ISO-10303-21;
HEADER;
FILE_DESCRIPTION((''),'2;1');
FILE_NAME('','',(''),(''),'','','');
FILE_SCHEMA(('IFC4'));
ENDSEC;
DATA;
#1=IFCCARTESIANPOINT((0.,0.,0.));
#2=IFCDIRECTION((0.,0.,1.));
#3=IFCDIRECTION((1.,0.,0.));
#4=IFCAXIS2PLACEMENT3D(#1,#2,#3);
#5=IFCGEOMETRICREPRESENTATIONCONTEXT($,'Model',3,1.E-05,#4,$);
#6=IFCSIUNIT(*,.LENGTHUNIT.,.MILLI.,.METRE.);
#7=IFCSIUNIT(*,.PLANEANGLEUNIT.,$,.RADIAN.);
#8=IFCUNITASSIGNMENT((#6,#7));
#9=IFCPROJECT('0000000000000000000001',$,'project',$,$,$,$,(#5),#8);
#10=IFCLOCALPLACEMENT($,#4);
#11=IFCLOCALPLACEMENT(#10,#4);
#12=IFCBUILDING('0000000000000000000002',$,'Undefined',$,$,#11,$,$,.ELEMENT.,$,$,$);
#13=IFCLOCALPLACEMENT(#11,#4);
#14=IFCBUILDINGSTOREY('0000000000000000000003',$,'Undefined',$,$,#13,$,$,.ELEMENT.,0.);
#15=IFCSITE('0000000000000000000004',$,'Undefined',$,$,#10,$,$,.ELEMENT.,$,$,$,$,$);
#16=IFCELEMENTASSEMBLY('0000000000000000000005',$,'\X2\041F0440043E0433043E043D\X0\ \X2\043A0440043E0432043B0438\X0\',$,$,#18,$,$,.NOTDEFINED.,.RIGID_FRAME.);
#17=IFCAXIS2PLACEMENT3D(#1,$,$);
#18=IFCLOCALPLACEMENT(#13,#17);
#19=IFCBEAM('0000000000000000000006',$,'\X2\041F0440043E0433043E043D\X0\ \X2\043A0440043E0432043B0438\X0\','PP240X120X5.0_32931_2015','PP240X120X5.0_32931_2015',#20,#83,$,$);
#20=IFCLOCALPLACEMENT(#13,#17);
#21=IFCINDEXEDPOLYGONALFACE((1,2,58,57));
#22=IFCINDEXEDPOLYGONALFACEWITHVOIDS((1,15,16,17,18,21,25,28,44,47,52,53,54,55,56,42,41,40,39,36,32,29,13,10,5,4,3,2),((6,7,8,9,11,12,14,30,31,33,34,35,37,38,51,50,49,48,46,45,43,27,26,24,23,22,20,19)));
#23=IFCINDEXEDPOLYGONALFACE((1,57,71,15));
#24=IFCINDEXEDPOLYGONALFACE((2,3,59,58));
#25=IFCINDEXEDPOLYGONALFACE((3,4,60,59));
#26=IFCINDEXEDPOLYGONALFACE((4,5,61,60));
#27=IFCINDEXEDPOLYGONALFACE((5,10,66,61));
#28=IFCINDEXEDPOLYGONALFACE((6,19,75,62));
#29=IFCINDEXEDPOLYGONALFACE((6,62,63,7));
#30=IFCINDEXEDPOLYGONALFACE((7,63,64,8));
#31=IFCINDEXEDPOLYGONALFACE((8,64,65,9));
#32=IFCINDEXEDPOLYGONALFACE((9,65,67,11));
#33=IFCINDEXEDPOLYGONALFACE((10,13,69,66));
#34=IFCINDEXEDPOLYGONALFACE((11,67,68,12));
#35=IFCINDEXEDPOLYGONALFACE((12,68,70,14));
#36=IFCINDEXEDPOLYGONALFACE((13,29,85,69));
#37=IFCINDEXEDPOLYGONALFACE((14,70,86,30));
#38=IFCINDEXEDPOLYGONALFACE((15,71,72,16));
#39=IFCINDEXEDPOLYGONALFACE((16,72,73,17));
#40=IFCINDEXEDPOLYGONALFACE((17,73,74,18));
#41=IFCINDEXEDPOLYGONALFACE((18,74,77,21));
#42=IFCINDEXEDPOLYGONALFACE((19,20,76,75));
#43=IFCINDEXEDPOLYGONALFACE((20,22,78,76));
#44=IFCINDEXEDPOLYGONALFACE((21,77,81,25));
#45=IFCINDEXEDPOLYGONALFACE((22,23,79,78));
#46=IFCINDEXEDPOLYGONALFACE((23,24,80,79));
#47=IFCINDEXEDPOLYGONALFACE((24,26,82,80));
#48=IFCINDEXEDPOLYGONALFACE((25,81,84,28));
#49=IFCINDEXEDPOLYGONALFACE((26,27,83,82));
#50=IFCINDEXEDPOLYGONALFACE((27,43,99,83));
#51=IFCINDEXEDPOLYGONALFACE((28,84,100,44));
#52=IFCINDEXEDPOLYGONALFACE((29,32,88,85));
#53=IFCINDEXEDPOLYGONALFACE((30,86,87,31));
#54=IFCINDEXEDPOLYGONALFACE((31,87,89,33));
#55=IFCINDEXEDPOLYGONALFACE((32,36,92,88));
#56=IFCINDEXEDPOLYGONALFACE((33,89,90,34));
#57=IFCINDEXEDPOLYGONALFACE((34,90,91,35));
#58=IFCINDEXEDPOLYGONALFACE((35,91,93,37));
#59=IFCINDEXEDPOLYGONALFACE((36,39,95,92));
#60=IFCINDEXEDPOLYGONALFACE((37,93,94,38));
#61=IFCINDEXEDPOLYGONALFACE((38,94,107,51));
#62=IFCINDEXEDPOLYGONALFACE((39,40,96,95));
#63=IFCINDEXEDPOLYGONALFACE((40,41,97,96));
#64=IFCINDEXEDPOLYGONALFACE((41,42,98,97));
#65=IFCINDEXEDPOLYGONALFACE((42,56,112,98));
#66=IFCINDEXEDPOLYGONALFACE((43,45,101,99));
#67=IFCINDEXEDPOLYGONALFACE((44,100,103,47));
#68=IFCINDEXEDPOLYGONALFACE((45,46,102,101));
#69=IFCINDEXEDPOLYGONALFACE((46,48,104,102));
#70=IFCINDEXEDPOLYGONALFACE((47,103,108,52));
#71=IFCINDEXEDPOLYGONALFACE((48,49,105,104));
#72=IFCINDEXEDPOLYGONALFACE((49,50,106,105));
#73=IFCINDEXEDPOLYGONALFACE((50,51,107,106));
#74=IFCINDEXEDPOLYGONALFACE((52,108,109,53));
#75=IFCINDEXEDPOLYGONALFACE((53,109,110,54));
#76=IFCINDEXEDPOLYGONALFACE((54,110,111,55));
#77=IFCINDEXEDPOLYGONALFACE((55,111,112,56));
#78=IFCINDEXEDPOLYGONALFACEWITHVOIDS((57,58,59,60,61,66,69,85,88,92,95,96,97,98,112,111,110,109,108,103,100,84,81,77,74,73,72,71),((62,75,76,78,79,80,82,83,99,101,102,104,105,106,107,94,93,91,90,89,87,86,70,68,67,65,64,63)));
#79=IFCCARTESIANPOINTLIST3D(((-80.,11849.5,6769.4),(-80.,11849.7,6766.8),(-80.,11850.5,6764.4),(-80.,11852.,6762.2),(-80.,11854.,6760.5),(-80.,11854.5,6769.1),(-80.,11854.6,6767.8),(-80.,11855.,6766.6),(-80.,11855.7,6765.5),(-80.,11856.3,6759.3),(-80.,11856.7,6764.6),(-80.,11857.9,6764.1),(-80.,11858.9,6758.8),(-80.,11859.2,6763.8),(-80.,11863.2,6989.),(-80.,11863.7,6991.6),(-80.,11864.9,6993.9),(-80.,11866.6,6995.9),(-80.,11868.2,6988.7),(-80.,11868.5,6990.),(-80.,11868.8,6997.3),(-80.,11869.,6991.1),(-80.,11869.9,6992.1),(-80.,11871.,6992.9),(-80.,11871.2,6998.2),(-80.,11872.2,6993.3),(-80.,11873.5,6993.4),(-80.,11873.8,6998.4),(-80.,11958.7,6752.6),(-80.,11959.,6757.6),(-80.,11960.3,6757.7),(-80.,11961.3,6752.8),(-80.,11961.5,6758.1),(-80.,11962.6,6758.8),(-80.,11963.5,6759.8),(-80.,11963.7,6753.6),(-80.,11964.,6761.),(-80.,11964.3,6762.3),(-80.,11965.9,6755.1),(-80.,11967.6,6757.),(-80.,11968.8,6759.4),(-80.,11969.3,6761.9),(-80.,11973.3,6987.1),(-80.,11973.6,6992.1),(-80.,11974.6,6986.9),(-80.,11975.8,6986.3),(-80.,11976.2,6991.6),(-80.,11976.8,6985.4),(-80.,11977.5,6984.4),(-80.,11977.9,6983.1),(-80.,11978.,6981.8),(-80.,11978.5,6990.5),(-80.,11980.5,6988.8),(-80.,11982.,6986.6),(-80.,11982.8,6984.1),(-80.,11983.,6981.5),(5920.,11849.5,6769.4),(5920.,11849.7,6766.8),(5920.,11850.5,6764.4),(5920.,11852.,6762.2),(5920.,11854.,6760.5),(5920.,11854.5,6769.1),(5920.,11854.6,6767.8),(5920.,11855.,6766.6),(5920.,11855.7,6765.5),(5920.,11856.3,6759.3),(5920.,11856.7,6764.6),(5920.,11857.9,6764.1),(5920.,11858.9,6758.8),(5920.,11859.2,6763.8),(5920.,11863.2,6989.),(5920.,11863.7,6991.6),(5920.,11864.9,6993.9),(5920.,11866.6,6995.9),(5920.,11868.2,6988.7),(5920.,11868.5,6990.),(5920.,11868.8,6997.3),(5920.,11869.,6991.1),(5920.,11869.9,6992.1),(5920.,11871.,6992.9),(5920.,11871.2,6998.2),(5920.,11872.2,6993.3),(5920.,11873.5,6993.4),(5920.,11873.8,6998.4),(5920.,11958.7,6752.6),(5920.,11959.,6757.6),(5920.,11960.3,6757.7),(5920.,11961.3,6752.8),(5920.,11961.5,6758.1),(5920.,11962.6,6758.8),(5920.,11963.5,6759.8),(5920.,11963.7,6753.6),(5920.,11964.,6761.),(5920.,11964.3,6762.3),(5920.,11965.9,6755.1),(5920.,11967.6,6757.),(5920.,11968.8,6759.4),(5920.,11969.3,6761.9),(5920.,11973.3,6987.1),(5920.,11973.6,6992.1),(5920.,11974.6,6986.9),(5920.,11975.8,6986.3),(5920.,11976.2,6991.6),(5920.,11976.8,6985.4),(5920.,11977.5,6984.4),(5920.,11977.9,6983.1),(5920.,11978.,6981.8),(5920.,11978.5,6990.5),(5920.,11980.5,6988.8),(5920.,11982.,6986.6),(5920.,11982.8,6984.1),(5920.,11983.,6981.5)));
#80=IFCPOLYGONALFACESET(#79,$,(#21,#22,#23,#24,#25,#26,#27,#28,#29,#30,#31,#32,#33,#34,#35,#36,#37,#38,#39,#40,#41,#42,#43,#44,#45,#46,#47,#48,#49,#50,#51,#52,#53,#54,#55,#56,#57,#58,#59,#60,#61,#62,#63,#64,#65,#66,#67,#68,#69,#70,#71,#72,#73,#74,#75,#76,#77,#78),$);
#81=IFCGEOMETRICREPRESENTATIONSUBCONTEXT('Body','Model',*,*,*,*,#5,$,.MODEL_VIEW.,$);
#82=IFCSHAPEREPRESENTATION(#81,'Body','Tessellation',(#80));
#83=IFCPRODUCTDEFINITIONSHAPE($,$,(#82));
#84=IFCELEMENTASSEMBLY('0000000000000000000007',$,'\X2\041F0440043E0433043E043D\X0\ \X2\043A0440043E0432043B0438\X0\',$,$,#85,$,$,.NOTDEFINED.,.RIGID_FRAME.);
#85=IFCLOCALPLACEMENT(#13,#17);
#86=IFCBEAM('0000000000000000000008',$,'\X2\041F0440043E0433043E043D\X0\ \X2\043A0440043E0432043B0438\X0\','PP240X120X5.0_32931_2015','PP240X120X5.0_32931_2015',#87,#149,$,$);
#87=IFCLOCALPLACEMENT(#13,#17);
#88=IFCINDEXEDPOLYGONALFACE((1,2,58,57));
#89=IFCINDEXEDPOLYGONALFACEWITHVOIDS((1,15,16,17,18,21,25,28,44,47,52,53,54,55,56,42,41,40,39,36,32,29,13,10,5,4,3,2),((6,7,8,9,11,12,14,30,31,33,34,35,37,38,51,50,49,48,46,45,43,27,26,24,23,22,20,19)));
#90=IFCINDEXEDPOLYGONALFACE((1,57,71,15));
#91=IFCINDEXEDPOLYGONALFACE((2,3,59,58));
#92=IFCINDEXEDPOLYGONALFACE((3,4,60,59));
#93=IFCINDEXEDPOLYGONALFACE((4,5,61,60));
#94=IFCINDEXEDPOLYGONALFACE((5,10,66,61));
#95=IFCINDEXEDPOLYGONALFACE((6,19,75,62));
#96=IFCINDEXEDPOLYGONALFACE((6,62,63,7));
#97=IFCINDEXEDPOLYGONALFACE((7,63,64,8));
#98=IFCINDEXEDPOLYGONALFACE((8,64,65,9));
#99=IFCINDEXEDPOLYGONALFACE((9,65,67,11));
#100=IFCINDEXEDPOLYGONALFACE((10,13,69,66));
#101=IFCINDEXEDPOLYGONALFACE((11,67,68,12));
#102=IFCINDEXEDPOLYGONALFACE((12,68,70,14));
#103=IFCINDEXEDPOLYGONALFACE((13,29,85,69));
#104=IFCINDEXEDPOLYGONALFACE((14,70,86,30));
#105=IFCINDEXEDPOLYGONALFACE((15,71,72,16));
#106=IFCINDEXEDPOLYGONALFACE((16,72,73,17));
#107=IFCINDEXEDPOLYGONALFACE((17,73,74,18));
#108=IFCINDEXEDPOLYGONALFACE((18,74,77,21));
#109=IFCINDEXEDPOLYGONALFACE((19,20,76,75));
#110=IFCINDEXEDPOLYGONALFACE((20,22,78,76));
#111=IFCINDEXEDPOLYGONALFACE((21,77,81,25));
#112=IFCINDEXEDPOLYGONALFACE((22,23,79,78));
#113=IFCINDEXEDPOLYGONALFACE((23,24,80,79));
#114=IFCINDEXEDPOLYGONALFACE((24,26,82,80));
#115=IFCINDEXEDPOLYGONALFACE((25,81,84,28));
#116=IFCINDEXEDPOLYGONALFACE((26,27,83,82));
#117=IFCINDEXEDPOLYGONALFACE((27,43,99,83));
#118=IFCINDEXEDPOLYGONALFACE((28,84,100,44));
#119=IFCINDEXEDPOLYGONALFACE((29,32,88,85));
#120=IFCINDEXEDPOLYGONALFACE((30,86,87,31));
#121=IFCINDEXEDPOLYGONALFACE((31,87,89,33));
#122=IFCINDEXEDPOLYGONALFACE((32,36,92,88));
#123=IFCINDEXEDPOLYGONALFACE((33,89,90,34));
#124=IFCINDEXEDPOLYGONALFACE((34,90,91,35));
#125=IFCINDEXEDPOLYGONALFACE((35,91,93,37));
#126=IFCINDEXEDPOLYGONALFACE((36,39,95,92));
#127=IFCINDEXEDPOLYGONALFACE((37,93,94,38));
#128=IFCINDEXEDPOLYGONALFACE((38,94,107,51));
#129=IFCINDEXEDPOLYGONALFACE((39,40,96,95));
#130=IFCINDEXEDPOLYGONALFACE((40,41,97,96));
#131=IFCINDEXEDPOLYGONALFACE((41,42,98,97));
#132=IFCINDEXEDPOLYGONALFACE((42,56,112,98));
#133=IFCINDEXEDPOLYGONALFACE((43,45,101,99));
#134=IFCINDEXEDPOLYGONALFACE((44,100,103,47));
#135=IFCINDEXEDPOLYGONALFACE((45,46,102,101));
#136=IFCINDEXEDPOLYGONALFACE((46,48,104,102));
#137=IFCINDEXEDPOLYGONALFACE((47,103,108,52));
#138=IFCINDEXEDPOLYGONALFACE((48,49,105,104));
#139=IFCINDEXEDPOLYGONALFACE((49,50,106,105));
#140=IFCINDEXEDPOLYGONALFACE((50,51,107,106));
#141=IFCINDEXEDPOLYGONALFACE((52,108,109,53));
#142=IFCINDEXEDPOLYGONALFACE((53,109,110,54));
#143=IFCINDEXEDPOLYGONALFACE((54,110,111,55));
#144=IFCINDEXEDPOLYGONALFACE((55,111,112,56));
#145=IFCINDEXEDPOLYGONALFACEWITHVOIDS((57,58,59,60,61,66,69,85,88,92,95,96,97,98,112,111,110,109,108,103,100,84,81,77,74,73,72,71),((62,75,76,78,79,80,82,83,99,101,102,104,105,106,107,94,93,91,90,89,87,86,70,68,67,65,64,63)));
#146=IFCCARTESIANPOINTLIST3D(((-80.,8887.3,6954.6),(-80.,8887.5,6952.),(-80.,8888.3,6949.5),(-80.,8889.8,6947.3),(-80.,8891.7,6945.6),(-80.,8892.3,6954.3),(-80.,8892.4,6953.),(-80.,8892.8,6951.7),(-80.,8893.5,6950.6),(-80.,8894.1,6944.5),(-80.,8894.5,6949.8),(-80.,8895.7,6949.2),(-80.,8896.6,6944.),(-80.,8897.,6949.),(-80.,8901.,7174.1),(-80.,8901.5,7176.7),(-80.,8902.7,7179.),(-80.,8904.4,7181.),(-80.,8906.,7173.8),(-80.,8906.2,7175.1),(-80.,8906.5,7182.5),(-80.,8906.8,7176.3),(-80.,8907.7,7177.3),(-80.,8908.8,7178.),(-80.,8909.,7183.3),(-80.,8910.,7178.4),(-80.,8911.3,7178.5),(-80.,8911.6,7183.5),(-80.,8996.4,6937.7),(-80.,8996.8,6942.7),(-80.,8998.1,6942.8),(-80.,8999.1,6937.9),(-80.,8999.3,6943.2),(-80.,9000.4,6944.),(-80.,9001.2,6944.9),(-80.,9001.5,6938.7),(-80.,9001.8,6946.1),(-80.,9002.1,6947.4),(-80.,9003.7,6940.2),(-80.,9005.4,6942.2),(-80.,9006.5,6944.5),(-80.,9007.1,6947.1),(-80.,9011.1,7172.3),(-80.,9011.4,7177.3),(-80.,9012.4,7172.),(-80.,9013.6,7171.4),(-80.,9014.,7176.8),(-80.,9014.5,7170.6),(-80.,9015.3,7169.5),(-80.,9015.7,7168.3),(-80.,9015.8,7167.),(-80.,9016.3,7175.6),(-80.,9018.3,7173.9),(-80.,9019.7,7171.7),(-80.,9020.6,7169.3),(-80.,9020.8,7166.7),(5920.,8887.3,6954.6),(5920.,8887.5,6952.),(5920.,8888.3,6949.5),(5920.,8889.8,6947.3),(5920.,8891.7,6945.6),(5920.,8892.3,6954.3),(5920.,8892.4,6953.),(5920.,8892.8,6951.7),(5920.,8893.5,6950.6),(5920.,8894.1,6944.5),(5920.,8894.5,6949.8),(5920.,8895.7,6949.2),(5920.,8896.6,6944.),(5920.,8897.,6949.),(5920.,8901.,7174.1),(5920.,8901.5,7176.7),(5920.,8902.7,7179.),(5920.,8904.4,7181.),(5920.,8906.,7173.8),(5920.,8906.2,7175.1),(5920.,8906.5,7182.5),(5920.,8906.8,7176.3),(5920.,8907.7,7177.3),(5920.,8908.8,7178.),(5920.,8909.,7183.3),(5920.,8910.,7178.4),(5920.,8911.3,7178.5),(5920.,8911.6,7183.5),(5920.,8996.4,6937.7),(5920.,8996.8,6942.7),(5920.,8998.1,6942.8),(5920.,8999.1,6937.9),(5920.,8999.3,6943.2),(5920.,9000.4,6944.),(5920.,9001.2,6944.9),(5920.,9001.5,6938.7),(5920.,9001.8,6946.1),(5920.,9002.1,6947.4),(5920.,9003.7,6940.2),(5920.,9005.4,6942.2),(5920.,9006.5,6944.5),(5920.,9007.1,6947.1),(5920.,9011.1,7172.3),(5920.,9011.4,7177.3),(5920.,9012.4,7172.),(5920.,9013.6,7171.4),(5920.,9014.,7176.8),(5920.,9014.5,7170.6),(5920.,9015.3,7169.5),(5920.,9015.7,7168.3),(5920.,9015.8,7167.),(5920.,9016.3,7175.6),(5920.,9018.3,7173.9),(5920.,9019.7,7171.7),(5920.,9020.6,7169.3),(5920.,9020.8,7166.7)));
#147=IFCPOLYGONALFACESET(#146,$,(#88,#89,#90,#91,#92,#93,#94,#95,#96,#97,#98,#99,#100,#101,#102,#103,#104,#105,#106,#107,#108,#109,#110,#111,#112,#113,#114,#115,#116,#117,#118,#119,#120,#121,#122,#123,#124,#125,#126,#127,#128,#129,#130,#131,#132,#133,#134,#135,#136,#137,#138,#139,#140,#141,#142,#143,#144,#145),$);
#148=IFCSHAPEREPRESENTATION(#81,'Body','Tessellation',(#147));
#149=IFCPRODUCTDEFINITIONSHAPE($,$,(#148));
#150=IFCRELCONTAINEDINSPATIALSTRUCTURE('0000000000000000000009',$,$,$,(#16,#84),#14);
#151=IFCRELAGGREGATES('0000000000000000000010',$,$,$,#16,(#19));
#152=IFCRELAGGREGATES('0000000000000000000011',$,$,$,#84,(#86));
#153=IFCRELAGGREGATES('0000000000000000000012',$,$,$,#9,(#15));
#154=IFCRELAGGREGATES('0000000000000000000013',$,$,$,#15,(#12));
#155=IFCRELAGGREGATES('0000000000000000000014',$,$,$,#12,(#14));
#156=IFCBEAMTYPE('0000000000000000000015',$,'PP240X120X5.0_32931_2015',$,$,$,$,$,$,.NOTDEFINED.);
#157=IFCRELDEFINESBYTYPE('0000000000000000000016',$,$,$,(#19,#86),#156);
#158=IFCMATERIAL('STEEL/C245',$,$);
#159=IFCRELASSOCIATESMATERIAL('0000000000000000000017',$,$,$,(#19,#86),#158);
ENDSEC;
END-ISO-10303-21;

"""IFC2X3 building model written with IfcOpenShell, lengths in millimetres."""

from ifc_helpers import new_model, si_unit, frame, origin_with_axes, origin_2d_with_axis, place, context, subcontext, project, spatial, hollow_rectangle, extrude, material, type_object, element, aggregate, save


model = new_model("IFC2X3")

# Units and contexts
model_context = context("Model", 3, precision=1e-05, world=origin_with_axes())
body_context = subcontext(model_context, "Body", "Model", "MODEL_VIEW")
ifc_project = project(units=[si_unit("LENGTHUNIT", "METRE", prefix="MILLI"), si_unit("PLANEANGLEUNIT", "RADIAN")], contexts=[model_context])

# Site, building, storey
site_placement = place(None, origin_with_axes())
site = spatial("IfcSite", under=ifc_project, at=site_placement, Name="Undefined", CompositionType="ELEMENT")
building_placement = place(site_placement, origin_with_axes())
building = spatial("IfcBuilding", under=site, at=building_placement, Name="Undefined", CompositionType="ELEMENT")
storey_placement = place(building_placement, origin_with_axes())
storey = spatial("IfcBuildingStorey", under=building, at=storey_placement, Name="Undefined", CompositionType="ELEMENT", Elevation=0.0)

# Shared definitions
ifc_material = material(Name="STEEL/C245")

# Element assemblies, beams
assembly_1_placement = place(storey_placement, origin_with_axes())
assembly_1 = element("IfcElementAssembly", 1, at=assembly_1_placement, inside=storey, Name="Прогон кровли", AssemblyPlace="NOTDEFINED", PredefinedType="RIGID_FRAME")
beam_type_1 = type_object("IfcBeamType", Name="PP240X120X5.0_32931_2015", PredefinedType="NOTDEFINED")
beam_1_placement = place(assembly_1_placement, frame((5920.0, 11916.2, 6875.5), z_axis=(0.0, 0.062378, 0.998053), x_axis=(-1.0, 0.0, 0.0)))
beam_1 = element("IfcBeam", 2, at=beam_1_placement, type_object=beam_type_1, material=ifc_material, Name="Прогон кровли", Description="PP240X120X5.0_32931_2015", ObjectType="PP240X120X5.0_32931_2015", context=body_context, shape_type="SweptSolid", body=[
    extrude(hollow_rectangle(XDim=120.0, YDim=240.0, WallThickness=5.0, InnerFilletRadius=5.0, OuterFilletRadius=10.0, at=origin_2d_with_axis()), frame((6000.0, 0.0, 0.0), z_axis=(-1.0, 0.0, 0.0), x_axis=(0.0, -1.0, 0.0)), (0.0, 0.0, 1.0), 6000.0),
])
aggregate(assembly_1, [beam_1])
assembly_2_placement = place(storey_placement, origin_with_axes())
assembly_2 = element("IfcElementAssembly", 3, at=assembly_2_placement, inside=storey, Name="Прогон кровли", AssemblyPlace="NOTDEFINED", PredefinedType="RIGID_FRAME")
beam_2_placement = place(assembly_2_placement, frame((5920.0, 8954.0, 7060.6), z_axis=(0.0, 0.062378, 0.998053), x_axis=(-1.0, 0.0, 0.0)))
beam_2 = element("IfcBeam", 4, at=beam_2_placement, type_object=beam_type_1, material=ifc_material, Name="Прогон кровли", Description="PP240X120X5.0_32931_2015", ObjectType="PP240X120X5.0_32931_2015", context=body_context, shape_type="SweptSolid", body=[
    extrude(hollow_rectangle(XDim=120.0, YDim=240.0, WallThickness=5.0, InnerFilletRadius=5.0, OuterFilletRadius=10.0, at=origin_2d_with_axis()), frame((6000.0, 0.0, 0.0), z_axis=(-1.0, 0.0, 0.0), x_axis=(0.0, -1.0, 0.0)), (0.0, 0.0, 1.0), 6000.0),
])
aggregate(assembly_2, [beam_2])

save(model, "model.ifc")
